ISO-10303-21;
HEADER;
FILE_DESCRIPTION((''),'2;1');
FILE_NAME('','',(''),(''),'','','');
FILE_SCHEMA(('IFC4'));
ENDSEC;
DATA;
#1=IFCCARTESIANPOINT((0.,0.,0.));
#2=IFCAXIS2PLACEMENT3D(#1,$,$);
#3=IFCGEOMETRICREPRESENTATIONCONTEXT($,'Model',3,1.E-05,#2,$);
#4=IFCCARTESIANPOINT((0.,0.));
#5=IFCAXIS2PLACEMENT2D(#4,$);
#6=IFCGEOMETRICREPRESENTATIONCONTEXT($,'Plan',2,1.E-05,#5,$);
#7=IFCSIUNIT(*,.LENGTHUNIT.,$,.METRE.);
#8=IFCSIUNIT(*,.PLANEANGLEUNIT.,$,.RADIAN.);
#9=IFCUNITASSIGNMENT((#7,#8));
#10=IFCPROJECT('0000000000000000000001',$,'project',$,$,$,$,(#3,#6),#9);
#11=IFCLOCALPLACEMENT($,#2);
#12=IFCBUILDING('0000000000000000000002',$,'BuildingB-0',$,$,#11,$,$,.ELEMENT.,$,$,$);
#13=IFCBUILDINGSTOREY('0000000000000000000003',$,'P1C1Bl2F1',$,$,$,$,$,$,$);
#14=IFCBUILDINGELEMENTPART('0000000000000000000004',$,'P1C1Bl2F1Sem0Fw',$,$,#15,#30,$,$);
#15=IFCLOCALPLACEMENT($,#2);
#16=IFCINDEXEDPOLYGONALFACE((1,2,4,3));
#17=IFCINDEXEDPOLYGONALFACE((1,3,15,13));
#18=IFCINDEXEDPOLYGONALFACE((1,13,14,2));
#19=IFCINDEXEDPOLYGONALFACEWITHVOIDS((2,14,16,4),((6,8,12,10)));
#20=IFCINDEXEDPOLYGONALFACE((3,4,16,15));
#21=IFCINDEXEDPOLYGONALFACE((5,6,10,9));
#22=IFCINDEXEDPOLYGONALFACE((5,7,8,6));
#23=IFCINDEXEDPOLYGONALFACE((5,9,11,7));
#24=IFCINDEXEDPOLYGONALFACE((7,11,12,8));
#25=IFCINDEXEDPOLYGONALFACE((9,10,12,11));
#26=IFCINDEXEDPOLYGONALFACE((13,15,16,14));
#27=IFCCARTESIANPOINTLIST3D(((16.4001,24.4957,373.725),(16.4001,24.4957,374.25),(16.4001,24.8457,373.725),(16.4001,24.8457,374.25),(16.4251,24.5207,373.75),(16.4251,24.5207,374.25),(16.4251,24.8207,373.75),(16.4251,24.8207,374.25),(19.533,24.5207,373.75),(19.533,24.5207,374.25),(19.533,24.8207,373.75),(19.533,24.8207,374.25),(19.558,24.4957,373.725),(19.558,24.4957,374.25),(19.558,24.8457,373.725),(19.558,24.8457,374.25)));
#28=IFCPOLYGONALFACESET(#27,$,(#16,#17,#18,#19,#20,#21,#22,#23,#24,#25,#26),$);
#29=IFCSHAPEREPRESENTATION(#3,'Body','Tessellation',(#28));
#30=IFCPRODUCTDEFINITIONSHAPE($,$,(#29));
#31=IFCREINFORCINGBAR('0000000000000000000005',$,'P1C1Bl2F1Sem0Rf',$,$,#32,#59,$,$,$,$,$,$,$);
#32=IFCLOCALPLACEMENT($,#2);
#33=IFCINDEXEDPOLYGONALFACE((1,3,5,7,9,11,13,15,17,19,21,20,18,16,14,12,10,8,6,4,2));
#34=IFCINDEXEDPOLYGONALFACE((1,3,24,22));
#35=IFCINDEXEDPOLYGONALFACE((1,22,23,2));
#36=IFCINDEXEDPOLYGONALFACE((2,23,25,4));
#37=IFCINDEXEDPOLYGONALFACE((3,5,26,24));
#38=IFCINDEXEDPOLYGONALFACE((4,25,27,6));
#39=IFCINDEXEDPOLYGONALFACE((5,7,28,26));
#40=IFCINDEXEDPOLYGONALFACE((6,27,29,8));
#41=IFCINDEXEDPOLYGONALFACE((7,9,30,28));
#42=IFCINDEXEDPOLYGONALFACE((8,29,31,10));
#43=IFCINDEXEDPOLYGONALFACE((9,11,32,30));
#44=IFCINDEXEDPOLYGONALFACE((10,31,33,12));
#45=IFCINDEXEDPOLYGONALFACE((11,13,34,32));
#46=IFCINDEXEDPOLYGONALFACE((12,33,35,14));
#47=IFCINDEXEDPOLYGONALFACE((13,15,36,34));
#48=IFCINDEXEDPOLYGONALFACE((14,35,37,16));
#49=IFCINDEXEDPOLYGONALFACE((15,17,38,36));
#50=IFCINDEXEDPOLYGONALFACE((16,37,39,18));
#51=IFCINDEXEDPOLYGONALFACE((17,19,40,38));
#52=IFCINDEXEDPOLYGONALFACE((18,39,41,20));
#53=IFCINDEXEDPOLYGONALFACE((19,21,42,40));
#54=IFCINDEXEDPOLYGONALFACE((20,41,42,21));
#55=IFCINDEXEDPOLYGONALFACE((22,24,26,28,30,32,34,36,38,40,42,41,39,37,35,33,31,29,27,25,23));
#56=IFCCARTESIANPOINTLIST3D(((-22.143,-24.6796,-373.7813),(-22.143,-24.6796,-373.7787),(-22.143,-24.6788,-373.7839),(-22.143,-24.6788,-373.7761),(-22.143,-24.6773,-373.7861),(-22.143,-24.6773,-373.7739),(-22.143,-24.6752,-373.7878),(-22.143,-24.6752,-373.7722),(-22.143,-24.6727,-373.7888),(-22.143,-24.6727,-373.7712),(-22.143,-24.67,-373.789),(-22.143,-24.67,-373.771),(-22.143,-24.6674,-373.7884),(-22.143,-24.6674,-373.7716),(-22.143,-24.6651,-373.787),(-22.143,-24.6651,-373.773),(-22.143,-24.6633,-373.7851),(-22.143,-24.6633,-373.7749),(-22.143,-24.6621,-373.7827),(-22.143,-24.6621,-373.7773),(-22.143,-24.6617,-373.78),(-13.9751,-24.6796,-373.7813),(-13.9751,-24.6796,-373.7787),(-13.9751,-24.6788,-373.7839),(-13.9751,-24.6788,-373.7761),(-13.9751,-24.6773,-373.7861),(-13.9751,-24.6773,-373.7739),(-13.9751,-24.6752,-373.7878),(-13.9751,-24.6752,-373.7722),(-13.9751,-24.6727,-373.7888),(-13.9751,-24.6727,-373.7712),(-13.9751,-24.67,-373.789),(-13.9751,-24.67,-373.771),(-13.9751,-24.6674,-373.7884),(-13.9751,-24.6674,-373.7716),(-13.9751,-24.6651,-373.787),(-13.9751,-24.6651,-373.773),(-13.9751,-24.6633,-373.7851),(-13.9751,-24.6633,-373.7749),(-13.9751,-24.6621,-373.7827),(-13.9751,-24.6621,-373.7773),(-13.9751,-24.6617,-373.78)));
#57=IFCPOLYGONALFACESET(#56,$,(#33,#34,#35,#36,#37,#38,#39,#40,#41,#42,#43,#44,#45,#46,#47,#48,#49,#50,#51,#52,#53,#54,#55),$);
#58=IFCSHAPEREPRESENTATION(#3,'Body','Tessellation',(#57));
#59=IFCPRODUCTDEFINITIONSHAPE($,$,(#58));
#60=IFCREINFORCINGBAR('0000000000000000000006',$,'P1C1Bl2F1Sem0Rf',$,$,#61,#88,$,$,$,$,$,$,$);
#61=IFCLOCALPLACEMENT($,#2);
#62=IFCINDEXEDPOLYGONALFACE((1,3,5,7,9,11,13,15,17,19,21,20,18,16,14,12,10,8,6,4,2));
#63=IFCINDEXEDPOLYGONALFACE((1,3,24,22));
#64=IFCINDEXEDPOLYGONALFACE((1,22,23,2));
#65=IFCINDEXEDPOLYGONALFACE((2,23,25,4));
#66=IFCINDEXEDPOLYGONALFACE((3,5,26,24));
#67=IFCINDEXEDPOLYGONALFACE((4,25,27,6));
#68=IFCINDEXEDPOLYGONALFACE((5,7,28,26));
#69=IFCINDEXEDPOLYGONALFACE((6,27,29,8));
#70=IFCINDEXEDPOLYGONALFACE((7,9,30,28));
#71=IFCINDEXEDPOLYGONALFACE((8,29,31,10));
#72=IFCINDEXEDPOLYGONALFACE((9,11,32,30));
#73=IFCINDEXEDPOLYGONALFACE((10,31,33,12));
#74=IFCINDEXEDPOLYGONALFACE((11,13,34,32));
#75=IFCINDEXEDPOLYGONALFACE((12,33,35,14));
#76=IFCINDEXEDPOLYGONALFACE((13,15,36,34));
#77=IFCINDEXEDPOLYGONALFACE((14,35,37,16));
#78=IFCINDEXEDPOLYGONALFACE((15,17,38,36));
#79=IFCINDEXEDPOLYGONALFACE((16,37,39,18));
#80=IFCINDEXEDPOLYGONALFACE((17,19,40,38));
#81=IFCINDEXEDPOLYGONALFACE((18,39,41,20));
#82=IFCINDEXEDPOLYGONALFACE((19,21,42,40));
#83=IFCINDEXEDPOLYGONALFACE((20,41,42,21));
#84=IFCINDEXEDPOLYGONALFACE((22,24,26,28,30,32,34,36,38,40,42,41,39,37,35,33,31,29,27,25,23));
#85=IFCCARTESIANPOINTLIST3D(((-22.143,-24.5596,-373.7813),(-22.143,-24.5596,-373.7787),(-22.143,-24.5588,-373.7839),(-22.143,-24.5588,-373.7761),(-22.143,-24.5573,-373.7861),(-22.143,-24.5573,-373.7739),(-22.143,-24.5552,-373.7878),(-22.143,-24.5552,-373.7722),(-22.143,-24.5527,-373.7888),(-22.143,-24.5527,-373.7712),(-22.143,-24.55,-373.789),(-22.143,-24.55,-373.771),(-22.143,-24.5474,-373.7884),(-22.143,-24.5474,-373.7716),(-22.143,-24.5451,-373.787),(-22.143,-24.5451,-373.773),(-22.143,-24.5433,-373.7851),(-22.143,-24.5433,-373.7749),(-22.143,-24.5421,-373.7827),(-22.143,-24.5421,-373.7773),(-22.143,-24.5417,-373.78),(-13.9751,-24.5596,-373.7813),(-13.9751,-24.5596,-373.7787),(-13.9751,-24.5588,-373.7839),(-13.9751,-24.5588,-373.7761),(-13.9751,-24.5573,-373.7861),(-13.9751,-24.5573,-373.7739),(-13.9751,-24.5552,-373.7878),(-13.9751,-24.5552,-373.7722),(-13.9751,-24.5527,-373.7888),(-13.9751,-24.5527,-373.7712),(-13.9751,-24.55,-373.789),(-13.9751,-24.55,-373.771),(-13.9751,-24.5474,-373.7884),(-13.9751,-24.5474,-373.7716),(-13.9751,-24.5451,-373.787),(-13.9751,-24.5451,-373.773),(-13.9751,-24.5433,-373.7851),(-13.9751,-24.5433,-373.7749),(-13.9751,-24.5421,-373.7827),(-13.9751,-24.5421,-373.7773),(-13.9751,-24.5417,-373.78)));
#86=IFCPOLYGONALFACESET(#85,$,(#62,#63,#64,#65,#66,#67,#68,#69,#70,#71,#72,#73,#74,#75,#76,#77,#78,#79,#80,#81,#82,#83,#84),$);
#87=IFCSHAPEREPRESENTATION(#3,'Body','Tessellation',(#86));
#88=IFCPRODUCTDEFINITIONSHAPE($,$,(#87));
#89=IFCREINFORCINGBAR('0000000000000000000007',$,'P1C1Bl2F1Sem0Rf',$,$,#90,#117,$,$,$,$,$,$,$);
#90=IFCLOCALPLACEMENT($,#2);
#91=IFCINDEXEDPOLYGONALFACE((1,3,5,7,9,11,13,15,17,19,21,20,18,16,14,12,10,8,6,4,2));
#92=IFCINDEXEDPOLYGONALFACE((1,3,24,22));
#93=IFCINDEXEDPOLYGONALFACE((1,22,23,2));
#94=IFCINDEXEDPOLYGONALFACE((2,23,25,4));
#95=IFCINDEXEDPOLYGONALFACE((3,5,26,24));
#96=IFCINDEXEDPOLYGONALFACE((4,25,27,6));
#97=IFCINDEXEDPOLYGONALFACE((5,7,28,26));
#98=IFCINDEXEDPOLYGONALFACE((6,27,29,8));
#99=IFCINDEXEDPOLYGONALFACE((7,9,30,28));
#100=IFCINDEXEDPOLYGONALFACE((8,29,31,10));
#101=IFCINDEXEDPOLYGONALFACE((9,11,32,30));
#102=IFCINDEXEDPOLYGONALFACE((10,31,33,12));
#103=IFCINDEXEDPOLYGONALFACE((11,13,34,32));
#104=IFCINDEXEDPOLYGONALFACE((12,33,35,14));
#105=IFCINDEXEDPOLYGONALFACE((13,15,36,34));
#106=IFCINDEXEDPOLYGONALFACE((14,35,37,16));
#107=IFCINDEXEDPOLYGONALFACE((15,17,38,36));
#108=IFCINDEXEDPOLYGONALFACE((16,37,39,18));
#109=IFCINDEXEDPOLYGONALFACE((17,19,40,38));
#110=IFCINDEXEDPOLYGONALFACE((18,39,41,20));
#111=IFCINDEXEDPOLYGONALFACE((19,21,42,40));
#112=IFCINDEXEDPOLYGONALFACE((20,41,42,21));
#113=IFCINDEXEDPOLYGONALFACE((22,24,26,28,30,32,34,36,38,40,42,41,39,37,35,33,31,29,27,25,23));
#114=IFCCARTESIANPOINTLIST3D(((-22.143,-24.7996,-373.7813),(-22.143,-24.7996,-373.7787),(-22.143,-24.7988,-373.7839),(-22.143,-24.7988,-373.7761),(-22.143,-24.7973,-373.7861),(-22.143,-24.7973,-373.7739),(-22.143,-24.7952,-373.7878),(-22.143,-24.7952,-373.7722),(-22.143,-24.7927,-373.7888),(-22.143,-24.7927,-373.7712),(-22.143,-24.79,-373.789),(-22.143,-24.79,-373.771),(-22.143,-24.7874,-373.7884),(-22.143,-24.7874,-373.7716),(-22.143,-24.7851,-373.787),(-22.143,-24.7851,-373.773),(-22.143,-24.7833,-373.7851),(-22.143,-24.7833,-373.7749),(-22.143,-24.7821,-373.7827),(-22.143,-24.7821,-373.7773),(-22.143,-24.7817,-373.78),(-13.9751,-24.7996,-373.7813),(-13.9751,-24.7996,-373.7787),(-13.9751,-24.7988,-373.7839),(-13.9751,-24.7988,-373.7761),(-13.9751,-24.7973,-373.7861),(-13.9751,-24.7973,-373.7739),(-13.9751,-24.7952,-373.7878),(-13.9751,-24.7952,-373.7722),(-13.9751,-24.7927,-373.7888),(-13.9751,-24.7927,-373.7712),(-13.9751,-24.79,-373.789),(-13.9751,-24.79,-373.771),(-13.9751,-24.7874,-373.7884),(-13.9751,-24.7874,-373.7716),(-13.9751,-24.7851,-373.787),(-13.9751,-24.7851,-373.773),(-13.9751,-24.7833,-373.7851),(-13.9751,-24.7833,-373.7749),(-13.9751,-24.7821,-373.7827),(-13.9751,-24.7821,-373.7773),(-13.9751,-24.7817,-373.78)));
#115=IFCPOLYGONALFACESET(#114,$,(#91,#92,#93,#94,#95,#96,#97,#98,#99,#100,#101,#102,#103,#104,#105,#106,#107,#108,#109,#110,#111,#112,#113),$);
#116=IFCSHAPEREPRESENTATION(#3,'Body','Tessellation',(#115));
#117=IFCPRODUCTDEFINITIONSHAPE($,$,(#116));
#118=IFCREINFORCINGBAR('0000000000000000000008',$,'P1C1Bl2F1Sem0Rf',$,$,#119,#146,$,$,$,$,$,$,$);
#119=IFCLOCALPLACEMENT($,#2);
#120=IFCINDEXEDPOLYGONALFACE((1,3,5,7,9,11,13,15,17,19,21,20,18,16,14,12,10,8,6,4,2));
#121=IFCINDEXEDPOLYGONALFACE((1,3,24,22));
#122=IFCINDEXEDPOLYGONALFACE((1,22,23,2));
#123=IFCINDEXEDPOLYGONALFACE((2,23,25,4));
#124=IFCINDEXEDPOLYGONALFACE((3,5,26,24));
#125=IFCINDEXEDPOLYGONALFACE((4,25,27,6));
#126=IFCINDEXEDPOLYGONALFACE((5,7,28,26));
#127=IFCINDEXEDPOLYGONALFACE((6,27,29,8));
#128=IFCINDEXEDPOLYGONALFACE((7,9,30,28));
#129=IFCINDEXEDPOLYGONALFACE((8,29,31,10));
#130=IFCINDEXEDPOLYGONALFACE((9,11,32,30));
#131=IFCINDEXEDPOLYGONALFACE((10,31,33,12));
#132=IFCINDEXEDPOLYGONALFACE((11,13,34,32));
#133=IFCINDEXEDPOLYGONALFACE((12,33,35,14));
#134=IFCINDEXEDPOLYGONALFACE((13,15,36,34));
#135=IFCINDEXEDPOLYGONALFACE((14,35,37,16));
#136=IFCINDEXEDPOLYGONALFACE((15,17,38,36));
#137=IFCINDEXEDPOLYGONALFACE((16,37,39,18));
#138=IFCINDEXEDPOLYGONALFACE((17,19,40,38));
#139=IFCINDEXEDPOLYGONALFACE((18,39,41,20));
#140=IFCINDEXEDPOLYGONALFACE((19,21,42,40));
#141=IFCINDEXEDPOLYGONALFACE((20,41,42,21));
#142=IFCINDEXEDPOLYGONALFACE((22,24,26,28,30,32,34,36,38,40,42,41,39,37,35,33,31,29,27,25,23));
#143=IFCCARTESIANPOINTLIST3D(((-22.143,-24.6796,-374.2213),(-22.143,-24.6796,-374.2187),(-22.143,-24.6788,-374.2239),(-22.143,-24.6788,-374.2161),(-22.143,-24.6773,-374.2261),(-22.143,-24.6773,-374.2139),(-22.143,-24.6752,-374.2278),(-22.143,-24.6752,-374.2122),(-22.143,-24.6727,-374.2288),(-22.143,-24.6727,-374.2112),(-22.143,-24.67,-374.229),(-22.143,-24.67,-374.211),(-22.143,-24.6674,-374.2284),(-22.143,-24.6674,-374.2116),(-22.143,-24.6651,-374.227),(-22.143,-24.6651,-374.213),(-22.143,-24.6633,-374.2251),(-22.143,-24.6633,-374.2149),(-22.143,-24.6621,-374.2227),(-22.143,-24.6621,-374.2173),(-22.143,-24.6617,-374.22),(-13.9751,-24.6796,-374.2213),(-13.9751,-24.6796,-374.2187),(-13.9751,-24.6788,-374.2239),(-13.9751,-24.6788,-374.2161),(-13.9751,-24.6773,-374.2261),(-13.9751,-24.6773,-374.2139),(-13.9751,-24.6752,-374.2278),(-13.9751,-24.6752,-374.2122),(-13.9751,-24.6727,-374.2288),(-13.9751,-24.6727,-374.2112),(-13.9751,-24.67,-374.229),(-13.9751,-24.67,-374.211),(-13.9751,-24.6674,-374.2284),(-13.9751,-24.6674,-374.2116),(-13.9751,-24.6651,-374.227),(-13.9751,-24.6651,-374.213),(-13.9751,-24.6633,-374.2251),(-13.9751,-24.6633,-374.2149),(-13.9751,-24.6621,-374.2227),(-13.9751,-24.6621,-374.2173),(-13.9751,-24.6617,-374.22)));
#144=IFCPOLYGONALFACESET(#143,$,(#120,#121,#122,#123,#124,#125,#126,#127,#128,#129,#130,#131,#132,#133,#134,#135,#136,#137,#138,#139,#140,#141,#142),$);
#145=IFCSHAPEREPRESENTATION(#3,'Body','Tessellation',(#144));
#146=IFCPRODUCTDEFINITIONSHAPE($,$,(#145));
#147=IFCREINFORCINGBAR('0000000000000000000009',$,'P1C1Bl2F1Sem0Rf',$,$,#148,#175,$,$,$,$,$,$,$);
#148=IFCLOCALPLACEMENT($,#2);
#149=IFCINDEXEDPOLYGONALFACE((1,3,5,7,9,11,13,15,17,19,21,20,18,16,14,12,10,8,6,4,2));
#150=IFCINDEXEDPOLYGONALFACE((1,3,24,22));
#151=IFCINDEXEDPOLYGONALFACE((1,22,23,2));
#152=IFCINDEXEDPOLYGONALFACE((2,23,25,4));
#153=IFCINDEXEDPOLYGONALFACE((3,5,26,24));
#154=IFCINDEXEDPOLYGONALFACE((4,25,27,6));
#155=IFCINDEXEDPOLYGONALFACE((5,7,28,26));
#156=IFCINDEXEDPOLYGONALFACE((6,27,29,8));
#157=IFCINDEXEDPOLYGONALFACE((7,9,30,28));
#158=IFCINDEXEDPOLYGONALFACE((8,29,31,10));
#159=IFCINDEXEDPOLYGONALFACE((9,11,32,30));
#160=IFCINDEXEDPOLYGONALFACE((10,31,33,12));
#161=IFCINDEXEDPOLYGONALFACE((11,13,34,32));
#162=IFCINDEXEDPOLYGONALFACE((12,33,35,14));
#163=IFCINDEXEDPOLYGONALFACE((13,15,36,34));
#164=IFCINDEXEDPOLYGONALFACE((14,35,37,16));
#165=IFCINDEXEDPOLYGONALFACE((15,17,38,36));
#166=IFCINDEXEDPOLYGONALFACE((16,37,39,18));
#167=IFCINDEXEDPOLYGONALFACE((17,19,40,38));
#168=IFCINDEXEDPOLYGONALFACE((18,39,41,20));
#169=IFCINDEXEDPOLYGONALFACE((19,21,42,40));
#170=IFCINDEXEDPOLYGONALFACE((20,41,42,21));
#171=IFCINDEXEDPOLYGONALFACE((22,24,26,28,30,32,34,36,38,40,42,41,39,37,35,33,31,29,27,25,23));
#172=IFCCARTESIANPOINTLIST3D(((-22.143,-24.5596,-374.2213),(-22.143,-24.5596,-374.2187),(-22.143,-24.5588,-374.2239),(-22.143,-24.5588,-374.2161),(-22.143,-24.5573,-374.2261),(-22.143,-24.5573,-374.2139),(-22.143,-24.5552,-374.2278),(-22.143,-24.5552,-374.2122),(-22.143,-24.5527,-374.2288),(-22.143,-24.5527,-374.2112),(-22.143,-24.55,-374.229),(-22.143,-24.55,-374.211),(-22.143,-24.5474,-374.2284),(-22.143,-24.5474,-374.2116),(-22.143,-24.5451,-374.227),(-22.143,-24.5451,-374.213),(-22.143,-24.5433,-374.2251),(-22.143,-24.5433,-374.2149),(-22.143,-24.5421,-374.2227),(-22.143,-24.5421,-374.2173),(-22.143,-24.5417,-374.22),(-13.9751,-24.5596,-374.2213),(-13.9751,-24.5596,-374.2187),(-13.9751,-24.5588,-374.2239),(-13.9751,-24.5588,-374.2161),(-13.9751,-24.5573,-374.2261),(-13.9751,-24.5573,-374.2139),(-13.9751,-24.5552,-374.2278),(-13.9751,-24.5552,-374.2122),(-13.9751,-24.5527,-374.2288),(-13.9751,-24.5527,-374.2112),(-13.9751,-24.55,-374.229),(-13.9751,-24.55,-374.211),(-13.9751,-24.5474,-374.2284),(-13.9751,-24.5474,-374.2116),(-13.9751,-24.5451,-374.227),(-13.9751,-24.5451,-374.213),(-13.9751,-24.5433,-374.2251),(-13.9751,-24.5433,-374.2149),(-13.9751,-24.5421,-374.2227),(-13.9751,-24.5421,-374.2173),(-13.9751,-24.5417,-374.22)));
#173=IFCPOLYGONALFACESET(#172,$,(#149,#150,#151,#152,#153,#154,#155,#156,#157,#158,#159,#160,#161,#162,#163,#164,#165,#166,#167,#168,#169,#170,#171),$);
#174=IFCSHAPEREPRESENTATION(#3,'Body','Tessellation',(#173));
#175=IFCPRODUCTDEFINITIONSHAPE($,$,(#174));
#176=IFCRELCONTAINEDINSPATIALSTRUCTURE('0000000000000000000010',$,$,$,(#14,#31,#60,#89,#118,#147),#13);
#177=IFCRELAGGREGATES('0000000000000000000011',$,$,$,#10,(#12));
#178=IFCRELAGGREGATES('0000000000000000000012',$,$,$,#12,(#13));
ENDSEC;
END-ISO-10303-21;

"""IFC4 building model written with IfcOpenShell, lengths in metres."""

from ifc_helpers import new_model, entity, si_unit, origin, origin_2d, place, context, project, spatial, polyline, outline, extrude, element, save


model = new_model("IFC4")

# Units and contexts
model_context = context("Model", 3, precision=1e-05, world=origin())
plan_context = context("Plan", 2, precision=1e-05, world=origin_2d())
ifc_project = project(units=[si_unit("LENGTHUNIT", "METRE"), si_unit("PLANEANGLEUNIT", "RADIAN")], contexts=[model_context, plan_context])

# Building, storey
building_placement = place(None, origin())
building = spatial("IfcBuilding", under=ifc_project, at=building_placement, Name="BuildingB-0", CompositionType="ELEMENT")
storey = spatial("IfcBuildingStorey", under=building, Name="P1C1Bl2F1")

# Building element part, opening
building_element_part_1 = element("IfcBuildingElementPart", 1, inside=storey, Name="P1C1Bl2F1Sem0Fw", context=model_context, shape_type="SweptSolid", body=[
    extrude(outline(polyline([(16.4001, 24.4957, 373.725), (16.4001, 24.8457, 373.725), (19.558, 24.8457, 373.725), (19.558, 24.4957, 373.725), (16.4001, 24.4957, 373.725)])), None, (0.0, 0.0, 1.0), 0.525),
])
element("IfcOpeningElement", 2, inside=storey, cuts=building_element_part_1, context=model_context, shape_type="SweptSolid", body=[
    extrude(outline(polyline([(16.4251, 24.5207, 373.75), (16.4251, 24.8207, 373.75), (19.533, 24.8207, 373.75), (19.533, 24.5207, 373.75), (16.4251, 24.5207, 373.75)])), None, (0.0, 0.0, 1.0), 0.5),
])

# Reinforcing bars
element("IfcReinforcingBar", 3, inside=storey, Name="P1C1Bl2F1Sem0Rf", context=model_context, shape_type="SweptSolid", body=[
    entity("IfcSurfaceCurveSweptAreaSolid", entity("IfcCircleProfileDef", "AREA", None, None, 0.009), None, entity("IfcPolyline", [entity("IfcCartesianPoint", [13.9751, 24.6707, 373.78]), entity("IfcCartesianPoint", [22.143, 24.6707, 373.78])]), None, None, entity("IfcPlane", entity("IfcAxis2Placement3D", entity("IfcCartesianPoint", [13.9751, 24.6707, 373.78]), entity("IfcDirection", [0.0, 0.0, 1.0]), entity("IfcDirection", [1.0, 0.0, 0.0])))),
])
element("IfcReinforcingBar", 4, inside=storey, Name="P1C1Bl2F1Sem0Rf", context=model_context, shape_type="SweptSolid", body=[
    entity("IfcSurfaceCurveSweptAreaSolid", entity("IfcCircleProfileDef", "AREA", None, None, 0.009), None, entity("IfcPolyline", [entity("IfcCartesianPoint", [13.9751, 24.5507, 373.78]), entity("IfcCartesianPoint", [22.143, 24.5507, 373.78])]), None, None, entity("IfcPlane", entity("IfcAxis2Placement3D", entity("IfcCartesianPoint", [13.9751, 24.5507, 373.78]), entity("IfcDirection", [0.0, 0.0, 1.0]), entity("IfcDirection", [1.0, 0.0, 0.0])))),
])
element("IfcReinforcingBar", 5, inside=storey, Name="P1C1Bl2F1Sem0Rf", context=model_context, shape_type="SweptSolid", body=[
    entity("IfcSurfaceCurveSweptAreaSolid", entity("IfcCircleProfileDef", "AREA", None, None, 0.009), None, entity("IfcPolyline", [entity("IfcCartesianPoint", [13.9751, 24.7907, 373.78]), entity("IfcCartesianPoint", [22.143, 24.7907, 373.78])]), None, None, entity("IfcPlane", entity("IfcAxis2Placement3D", entity("IfcCartesianPoint", [13.9751, 24.7907, 373.78]), entity("IfcDirection", [0.0, 0.0, 1.0]), entity("IfcDirection", [1.0, 0.0, 0.0])))),
])
element("IfcReinforcingBar", 6, inside=storey, Name="P1C1Bl2F1Sem0Rf", context=model_context, shape_type="SweptSolid", body=[
    entity("IfcSurfaceCurveSweptAreaSolid", entity("IfcCircleProfileDef", "AREA", None, None, 0.009), None, entity("IfcPolyline", [entity("IfcCartesianPoint", [13.9751, 24.6707, 374.22]), entity("IfcCartesianPoint", [22.143, 24.6707, 374.22])]), None, None, entity("IfcPlane", entity("IfcAxis2Placement3D", entity("IfcCartesianPoint", [13.9751, 24.6707, 374.22]), entity("IfcDirection", [0.0, 0.0, 1.0]), entity("IfcDirection", [1.0, 0.0, 0.0])))),
])
element("IfcReinforcingBar", 7, inside=storey, Name="P1C1Bl2F1Sem0Rf", context=model_context, shape_type="SweptSolid", body=[
    entity("IfcSurfaceCurveSweptAreaSolid", entity("IfcCircleProfileDef", "AREA", None, None, 0.009), None, entity("IfcPolyline", [entity("IfcCartesianPoint", [13.9751, 24.5507, 374.22]), entity("IfcCartesianPoint", [22.143, 24.5507, 374.22])]), None, None, entity("IfcPlane", entity("IfcAxis2Placement3D", entity("IfcCartesianPoint", [13.9751, 24.5507, 374.22]), entity("IfcDirection", [0.0, 0.0, 1.0]), entity("IfcDirection", [1.0, 0.0, 0.0])))),
])

save(model, "model.ifc")
